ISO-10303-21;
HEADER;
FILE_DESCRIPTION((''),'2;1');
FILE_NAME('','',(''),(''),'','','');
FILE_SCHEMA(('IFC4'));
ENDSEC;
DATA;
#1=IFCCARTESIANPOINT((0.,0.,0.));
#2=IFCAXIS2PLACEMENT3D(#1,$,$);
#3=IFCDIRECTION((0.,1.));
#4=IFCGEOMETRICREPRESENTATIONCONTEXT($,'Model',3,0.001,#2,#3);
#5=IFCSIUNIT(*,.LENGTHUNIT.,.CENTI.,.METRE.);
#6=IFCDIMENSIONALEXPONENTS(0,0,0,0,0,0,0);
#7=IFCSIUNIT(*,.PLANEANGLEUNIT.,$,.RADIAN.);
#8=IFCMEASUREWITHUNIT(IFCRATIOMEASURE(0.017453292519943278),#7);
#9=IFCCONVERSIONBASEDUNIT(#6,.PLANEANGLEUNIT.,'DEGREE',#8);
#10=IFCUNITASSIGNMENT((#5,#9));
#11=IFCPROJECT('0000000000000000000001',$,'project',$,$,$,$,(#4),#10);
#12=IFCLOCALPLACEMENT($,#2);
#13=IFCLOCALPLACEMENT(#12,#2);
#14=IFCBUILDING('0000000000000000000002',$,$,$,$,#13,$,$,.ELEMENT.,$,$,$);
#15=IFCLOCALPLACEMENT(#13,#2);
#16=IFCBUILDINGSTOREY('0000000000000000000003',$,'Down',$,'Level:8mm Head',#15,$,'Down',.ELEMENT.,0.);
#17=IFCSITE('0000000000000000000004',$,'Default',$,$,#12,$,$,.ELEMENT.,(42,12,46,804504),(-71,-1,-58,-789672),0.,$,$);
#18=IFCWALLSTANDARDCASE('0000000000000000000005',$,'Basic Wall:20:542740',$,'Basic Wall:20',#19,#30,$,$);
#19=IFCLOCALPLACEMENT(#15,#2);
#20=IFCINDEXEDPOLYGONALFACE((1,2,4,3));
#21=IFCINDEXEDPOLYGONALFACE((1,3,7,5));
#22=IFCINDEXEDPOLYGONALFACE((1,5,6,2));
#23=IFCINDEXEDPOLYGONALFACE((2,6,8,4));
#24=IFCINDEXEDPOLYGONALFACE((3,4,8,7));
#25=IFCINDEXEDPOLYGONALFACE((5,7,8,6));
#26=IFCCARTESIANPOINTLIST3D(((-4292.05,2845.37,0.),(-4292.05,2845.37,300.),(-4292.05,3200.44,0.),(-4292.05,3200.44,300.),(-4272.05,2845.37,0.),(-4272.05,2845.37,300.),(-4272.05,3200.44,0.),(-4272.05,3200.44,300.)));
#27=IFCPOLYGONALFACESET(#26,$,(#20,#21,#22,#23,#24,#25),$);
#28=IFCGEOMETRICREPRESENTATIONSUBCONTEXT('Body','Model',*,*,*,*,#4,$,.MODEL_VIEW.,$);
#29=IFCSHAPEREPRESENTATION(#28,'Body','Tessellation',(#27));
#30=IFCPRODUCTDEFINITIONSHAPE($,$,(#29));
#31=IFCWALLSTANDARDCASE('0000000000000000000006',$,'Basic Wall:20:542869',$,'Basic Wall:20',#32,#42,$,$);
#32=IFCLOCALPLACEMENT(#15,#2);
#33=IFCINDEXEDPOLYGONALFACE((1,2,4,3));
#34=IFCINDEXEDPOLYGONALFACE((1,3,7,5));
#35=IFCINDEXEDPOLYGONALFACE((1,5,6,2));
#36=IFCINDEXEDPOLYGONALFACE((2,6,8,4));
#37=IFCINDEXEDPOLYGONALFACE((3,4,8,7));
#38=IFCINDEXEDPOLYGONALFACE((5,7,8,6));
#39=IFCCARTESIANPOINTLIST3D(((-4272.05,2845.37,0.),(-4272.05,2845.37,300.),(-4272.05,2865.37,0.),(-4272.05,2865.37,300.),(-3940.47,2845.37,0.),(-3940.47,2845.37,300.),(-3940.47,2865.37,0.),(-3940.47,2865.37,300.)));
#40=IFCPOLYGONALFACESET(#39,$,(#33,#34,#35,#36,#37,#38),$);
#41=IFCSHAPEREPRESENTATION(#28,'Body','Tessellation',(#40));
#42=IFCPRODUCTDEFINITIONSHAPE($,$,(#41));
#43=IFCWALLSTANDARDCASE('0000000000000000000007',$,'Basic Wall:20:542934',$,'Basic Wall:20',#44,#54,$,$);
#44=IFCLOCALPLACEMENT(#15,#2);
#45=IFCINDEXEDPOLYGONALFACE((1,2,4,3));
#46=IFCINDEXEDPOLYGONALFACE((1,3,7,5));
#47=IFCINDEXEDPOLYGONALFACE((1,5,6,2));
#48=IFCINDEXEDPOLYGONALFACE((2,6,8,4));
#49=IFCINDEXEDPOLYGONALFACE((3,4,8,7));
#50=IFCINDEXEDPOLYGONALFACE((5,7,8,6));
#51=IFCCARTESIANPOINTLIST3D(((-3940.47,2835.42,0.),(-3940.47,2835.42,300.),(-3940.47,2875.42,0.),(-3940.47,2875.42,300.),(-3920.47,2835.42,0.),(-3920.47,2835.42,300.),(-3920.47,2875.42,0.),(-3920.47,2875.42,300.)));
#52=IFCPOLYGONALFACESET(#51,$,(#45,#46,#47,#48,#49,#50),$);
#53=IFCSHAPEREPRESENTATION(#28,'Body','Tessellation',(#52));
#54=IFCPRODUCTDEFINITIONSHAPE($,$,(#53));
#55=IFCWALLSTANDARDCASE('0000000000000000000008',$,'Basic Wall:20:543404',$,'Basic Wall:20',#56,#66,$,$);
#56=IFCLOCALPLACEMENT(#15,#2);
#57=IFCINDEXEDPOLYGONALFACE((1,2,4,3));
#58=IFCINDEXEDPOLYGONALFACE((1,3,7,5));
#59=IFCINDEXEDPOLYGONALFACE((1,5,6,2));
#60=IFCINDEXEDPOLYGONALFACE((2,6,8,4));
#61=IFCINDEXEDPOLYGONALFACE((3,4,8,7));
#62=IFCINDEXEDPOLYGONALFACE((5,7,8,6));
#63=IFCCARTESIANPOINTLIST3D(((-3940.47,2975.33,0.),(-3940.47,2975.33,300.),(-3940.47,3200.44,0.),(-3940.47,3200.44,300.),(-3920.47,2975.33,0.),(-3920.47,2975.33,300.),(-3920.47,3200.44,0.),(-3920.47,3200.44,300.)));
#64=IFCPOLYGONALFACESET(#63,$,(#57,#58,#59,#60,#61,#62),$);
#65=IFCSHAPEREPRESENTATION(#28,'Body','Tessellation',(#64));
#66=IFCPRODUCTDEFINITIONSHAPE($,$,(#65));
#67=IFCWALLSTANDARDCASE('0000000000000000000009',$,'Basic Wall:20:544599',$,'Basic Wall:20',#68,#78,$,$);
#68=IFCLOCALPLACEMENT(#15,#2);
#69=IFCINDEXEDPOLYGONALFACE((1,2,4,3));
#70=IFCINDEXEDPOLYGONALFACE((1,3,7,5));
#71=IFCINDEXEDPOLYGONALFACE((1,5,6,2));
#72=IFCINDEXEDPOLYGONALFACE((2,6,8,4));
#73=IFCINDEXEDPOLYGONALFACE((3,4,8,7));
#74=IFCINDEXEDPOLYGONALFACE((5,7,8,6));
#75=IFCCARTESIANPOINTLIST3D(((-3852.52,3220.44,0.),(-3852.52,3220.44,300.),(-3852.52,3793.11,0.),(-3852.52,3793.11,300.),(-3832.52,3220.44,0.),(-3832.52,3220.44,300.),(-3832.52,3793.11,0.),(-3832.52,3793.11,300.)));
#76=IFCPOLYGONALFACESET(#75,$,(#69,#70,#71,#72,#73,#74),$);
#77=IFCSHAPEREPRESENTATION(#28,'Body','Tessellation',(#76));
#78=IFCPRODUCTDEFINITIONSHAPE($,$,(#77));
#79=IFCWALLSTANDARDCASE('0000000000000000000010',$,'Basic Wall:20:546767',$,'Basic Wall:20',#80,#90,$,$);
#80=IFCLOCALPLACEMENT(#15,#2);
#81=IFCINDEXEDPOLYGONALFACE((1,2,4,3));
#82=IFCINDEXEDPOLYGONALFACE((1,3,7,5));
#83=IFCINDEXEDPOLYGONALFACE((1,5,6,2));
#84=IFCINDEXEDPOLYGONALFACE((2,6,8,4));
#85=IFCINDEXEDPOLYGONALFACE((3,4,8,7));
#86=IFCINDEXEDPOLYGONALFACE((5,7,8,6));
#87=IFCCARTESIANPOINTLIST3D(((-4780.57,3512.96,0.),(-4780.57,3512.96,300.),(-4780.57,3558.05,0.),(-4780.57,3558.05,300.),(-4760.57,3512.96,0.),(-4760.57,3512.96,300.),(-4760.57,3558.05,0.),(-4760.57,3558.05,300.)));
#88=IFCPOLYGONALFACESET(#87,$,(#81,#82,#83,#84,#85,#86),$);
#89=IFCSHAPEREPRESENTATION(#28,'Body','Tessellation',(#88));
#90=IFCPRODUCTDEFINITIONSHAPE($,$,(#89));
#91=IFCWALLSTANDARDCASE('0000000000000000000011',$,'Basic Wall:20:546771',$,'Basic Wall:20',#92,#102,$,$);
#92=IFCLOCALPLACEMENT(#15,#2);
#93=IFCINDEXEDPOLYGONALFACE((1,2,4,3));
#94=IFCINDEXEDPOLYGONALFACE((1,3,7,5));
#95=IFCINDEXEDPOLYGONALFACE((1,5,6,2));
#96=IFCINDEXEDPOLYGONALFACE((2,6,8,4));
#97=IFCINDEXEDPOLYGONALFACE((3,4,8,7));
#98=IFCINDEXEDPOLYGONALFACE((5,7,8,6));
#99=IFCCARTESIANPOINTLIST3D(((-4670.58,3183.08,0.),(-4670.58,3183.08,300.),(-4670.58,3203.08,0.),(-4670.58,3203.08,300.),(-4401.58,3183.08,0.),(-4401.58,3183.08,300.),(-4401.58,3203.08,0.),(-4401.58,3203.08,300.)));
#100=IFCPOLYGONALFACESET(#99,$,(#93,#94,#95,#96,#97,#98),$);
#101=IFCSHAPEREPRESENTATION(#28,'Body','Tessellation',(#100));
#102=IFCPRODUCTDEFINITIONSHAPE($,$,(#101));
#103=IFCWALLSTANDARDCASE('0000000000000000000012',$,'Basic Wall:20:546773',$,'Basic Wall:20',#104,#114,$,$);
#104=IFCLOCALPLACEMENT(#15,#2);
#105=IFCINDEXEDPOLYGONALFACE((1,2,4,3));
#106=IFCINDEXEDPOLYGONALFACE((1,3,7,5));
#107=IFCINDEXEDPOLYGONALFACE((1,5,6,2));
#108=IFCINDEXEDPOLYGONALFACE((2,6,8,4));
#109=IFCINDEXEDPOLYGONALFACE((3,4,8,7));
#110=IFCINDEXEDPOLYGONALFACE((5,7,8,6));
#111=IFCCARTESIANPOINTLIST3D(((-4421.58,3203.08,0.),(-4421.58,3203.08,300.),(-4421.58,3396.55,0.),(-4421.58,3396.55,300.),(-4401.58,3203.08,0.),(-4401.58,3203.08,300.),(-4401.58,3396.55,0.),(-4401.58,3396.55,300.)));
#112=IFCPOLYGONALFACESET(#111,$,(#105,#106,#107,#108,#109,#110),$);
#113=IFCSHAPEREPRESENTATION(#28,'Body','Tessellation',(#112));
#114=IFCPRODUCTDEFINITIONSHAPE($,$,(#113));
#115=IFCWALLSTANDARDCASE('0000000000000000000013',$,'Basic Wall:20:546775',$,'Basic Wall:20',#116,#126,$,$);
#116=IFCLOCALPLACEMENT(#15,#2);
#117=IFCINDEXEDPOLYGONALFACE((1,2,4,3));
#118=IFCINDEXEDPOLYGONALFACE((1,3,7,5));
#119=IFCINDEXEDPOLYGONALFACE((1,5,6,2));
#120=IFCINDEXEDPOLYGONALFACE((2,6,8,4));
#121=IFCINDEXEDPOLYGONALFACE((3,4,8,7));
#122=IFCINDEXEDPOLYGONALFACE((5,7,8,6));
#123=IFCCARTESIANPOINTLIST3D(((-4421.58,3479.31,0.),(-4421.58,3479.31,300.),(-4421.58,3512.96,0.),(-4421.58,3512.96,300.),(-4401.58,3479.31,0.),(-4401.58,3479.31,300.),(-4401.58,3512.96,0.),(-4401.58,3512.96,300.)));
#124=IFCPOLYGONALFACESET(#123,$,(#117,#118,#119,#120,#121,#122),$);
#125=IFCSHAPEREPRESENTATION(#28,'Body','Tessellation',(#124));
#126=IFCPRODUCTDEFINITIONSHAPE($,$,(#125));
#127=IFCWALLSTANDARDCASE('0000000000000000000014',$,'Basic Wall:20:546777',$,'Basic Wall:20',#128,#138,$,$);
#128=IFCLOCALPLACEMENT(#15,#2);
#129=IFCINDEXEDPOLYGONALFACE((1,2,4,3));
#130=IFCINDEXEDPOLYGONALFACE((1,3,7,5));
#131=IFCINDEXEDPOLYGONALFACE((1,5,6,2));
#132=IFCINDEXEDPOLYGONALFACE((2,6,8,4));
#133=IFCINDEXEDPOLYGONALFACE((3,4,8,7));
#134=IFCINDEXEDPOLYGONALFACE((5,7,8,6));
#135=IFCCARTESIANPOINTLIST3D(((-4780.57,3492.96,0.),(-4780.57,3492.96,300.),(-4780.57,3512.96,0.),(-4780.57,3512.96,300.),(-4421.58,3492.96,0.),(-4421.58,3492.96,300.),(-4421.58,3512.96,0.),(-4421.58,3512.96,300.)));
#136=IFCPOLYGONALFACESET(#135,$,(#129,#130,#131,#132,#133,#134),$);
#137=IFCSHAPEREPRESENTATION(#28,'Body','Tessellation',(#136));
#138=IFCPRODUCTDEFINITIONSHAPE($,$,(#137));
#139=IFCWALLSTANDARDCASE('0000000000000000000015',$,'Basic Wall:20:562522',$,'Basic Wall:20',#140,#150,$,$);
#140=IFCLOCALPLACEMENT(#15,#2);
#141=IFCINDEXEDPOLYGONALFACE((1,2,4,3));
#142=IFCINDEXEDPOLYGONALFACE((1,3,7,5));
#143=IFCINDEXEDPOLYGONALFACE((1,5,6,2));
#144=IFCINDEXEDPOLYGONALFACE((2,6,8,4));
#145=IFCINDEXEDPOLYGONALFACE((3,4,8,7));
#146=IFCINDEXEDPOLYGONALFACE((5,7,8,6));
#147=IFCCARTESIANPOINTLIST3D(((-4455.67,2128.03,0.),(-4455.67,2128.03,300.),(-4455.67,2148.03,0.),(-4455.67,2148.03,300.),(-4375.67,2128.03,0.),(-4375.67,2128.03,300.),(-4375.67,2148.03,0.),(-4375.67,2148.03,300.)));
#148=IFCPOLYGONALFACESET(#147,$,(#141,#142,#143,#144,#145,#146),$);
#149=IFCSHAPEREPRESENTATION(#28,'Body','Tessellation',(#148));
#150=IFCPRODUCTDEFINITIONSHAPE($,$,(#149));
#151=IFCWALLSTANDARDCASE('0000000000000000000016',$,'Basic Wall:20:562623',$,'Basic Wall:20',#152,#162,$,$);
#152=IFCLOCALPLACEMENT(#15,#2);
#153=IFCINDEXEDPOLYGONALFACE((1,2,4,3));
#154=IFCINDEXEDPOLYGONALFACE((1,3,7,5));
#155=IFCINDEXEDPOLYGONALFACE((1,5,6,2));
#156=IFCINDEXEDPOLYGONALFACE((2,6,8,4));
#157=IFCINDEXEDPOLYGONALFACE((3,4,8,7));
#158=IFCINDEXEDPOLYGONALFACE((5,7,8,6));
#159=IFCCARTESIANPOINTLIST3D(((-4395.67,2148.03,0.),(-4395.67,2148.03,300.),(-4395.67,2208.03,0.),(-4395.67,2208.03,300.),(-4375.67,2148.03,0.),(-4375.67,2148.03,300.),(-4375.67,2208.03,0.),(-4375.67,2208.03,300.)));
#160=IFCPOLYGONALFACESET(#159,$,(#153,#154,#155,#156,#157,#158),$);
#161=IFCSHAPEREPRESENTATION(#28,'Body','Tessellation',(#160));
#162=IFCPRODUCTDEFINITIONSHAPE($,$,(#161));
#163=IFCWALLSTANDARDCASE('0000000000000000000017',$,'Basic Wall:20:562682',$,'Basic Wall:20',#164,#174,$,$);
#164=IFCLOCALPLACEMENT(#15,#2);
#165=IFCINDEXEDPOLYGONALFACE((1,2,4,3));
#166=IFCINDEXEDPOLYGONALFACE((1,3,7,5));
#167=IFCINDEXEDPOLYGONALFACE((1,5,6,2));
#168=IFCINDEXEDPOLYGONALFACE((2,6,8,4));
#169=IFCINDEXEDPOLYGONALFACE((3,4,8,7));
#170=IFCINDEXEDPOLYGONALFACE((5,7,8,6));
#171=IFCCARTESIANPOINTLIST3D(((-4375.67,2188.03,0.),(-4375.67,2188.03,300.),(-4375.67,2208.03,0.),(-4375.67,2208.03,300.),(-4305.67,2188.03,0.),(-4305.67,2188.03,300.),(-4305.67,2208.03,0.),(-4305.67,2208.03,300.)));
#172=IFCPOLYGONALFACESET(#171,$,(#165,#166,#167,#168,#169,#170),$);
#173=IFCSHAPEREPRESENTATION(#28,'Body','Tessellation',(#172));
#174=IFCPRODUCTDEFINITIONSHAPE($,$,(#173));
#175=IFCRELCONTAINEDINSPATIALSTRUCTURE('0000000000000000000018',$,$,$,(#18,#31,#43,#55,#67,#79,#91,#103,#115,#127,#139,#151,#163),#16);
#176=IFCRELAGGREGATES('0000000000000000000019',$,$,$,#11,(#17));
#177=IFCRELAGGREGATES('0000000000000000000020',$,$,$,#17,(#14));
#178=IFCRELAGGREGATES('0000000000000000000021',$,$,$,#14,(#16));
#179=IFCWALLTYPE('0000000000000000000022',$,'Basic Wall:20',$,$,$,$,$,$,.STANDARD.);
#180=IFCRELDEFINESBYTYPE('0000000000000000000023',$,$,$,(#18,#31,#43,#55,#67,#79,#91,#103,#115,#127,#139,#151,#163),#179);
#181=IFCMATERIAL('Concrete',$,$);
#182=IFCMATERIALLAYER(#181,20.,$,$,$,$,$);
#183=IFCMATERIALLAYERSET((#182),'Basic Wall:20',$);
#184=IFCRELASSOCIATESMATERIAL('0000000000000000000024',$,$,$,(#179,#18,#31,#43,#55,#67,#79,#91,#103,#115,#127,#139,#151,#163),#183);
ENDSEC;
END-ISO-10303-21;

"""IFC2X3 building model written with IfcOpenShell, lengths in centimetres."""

from ifc_helpers import new_model, entity, si_unit, converted_unit, direction, frame, frame_2d, origin, place, context, subcontext, project, spatial, rectangle, extrude, material, layer, layer_set, layer_usage, type_object, element, save


model = new_model("IFC2X3")

# Units and contexts
model_context = context("Model", 3, precision=0.001, world=origin(), true_north=direction((0.0, 1.0)))
body_context = subcontext(model_context, "Body", "Model", "MODEL_VIEW")
ifc_project = project(units=[si_unit("LENGTHUNIT", "METRE", prefix="CENTI"), converted_unit("PLANEANGLEUNIT", "DEGREE", entity("IfcRatioMeasure", 0.017453292519943278), si_unit("PLANEANGLEUNIT", "RADIAN"), dimensions=[0, 0, 0, 0, 0, 0, 0])], contexts=[model_context])

# Site, building, storey
site_placement = place(None, origin())
site = spatial("IfcSite", under=ifc_project, at=site_placement, Name="Default", CompositionType="ELEMENT", RefLatitude=(42, 12, 46, 804504), RefLongitude=(-71, -1, -58, -789672), RefElevation=0.0)
building_placement = place(site_placement, origin())
building = spatial("IfcBuilding", under=site, at=building_placement, CompositionType="ELEMENT")
storey_placement = place(building_placement, origin())
storey = spatial("IfcBuildingStorey", under=building, at=storey_placement, Name="Down", ObjectType="Level:8mm Head", LongName="Down", CompositionType="ELEMENT", Elevation=0.0)

# Walls
ifc_material = material(Name="Concrete")
ifc_layer_1 = layer(ifc_material, 20.0)
ifc_layer_set_1 = layer_set([ifc_layer_1], Name="Basic Wall:20")
wall_type_1 = type_object("IfcWallType", Name="Basic Wall:20", PredefinedType="STANDARD", material=ifc_layer_set_1)
ifc_layer_usage_1 = layer_usage(ifc_layer_set_1, "AXIS2", "POSITIVE", -10.0)
wall_1_placement = place(storey_placement, frame((-4282.05, 3200.44, 0.0), z_axis=(0.0, 0.0, 1.0), x_axis=(0.0, -1.0, 0.0)))
element("IfcWallStandardCase", 1, at=wall_1_placement, inside=storey, type_object=wall_type_1, material=ifc_layer_usage_1, Name="Basic Wall:20:542740", ObjectType="Basic Wall:20", context=body_context, shape_type="SweptSolid", body=[
    extrude(rectangle(XDim=355.07, YDim=20.0, at=frame_2d((177.54, 0.0), x_axis=(-1.0, 0.0))), origin(), (0.0, 0.0, 1.0), 300.0),
])
ifc_layer_usage_2 = layer_usage(ifc_layer_set_1, "AXIS2", "POSITIVE", -10.0)
wall_2_placement = place(storey_placement, frame((-4272.05, 2855.37, 0.0)))
element("IfcWallStandardCase", 2, at=wall_2_placement, inside=storey, type_object=wall_type_1, material=ifc_layer_usage_2, Name="Basic Wall:20:542869", ObjectType="Basic Wall:20", context=body_context, shape_type="SweptSolid", body=[
    extrude(rectangle(XDim=331.58, YDim=20.0, at=frame_2d((165.79, 0.0), x_axis=(-1.0, 0.0))), origin(), (0.0, 0.0, 1.0), 300.0),
])
ifc_layer_usage_3 = layer_usage(ifc_layer_set_1, "AXIS2", "NEGATIVE", 10.0)
wall_3_placement = place(storey_placement, frame((-3930.47, 2875.42, 0.0), z_axis=(0.0, 0.0, 1.0), x_axis=(0.0, -1.0, 0.0)))
element("IfcWallStandardCase", 3, at=wall_3_placement, inside=storey, type_object=wall_type_1, material=ifc_layer_usage_3, Name="Basic Wall:20:542934", ObjectType="Basic Wall:20", context=body_context, shape_type="SweptSolid", body=[
    extrude(rectangle(XDim=40.0, YDim=20.0, at=frame_2d((20.0, 0.0), x_axis=(-1.0, 0.0))), origin(), (0.0, 0.0, 1.0), 300.0),
])
ifc_layer_usage_4 = layer_usage(ifc_layer_set_1, "AXIS2", "NEGATIVE", 10.0)
wall_4_placement = place(storey_placement, frame((-3930.47, 2975.33, 0.0), z_axis=(0.0, 0.0, 1.0), x_axis=(0.0, 1.0, 0.0)))
element("IfcWallStandardCase", 4, at=wall_4_placement, inside=storey, type_object=wall_type_1, material=ifc_layer_usage_4, Name="Basic Wall:20:543404", ObjectType="Basic Wall:20", context=body_context, shape_type="SweptSolid", body=[
    extrude(rectangle(XDim=225.11, YDim=20.0, at=frame_2d((112.56, 0.0), x_axis=(-1.0, 0.0))), origin(), (0.0, 0.0, 1.0), 300.0),
])
ifc_layer_usage_5 = layer_usage(ifc_layer_set_1, "AXIS2", "POSITIVE", -10.0)
wall_5_placement = place(storey_placement, frame((-3842.52, 3220.44, 0.0), z_axis=(0.0, 0.0, 1.0), x_axis=(0.0, 1.0, 0.0)))
element("IfcWallStandardCase", 5, at=wall_5_placement, inside=storey, type_object=wall_type_1, material=ifc_layer_usage_5, Name="Basic Wall:20:544599", ObjectType="Basic Wall:20", context=body_context, shape_type="SweptSolid", body=[
    extrude(rectangle(XDim=572.67, YDim=20.0, at=frame_2d((286.33, 0.0), x_axis=(-1.0, 0.0))), origin(), (0.0, 0.0, 1.0), 300.0),
])
ifc_layer_usage_6 = layer_usage(ifc_layer_set_1, "AXIS2", "NEGATIVE", 10.0)
wall_6_placement = place(storey_placement, frame((-4770.57, 3558.05, 0.0), z_axis=(0.0, 0.0, 1.0), x_axis=(0.0, -1.0, 0.0)))
element("IfcWallStandardCase", 6, at=wall_6_placement, inside=storey, type_object=wall_type_1, material=ifc_layer_usage_6, Name="Basic Wall:20:546767", ObjectType="Basic Wall:20", context=body_context, shape_type="SweptSolid", body=[
    extrude(rectangle(XDim=45.08, YDim=20.0, at=frame_2d((22.54, 0.0), x_axis=(-1.0, 0.0))), origin(), (0.0, 0.0, 1.0), 300.0),
])
ifc_layer_usage_7 = layer_usage(ifc_layer_set_1, "AXIS2", "NEGATIVE", 10.0)
wall_7_placement = place(storey_placement, frame((-4670.58, 3193.08, 0.0)))
element("IfcWallStandardCase", 7, at=wall_7_placement, inside=storey, type_object=wall_type_1, material=ifc_layer_usage_7, Name="Basic Wall:20:546771", ObjectType="Basic Wall:20", context=body_context, shape_type="SweptSolid", body=[
    extrude(rectangle(XDim=268.99, YDim=20.0, at=frame_2d((134.5, 0.0), x_axis=(-1.0, 0.0))), origin(), (0.0, 0.0, 1.0), 300.0),
])
ifc_layer_usage_8 = layer_usage(ifc_layer_set_1, "AXIS2", "POSITIVE", -10.0)
wall_8_placement = place(storey_placement, frame((-4411.58, 3203.08, 0.0), z_axis=(0.0, 0.0, 1.0), x_axis=(0.0, 1.0, 0.0)))
element("IfcWallStandardCase", 8, at=wall_8_placement, inside=storey, type_object=wall_type_1, material=ifc_layer_usage_8, Name="Basic Wall:20:546773", ObjectType="Basic Wall:20", context=body_context, shape_type="SweptSolid", body=[
    extrude(rectangle(XDim=193.46, YDim=20.0, at=frame_2d((96.73, 0.0), x_axis=(-1.0, 0.0))), origin(), (0.0, 0.0, 1.0), 300.0),
])
ifc_layer_usage_9 = layer_usage(ifc_layer_set_1, "AXIS2", "POSITIVE", -10.0)
wall_9_placement = place(storey_placement, frame((-4411.58, 3479.31, 0.0), z_axis=(0.0, 0.0, 1.0), x_axis=(0.0, 1.0, 0.0)))
element("IfcWallStandardCase", 9, at=wall_9_placement, inside=storey, type_object=wall_type_1, material=ifc_layer_usage_9, Name="Basic Wall:20:546775", ObjectType="Basic Wall:20", context=body_context, shape_type="SweptSolid", body=[
    extrude(rectangle(XDim=33.66, YDim=20.0, at=frame_2d((16.83, 0.0), x_axis=(-1.0, 0.0))), origin(), (0.0, 0.0, 1.0), 300.0),
])
ifc_layer_usage_10 = layer_usage(ifc_layer_set_1, "AXIS2", "POSITIVE", -10.0)
wall_10_placement = place(storey_placement, frame((-4421.58, 3502.96, 0.0), z_axis=(0.0, 0.0, 1.0), x_axis=(-1.0, 0.0, 0.0)))
element("IfcWallStandardCase", 10, at=wall_10_placement, inside=storey, type_object=wall_type_1, material=ifc_layer_usage_10, Name="Basic Wall:20:546777", ObjectType="Basic Wall:20", context=body_context, shape_type="SweptSolid", body=[
    extrude(rectangle(XDim=358.99, YDim=20.0, at=frame_2d((179.49, 0.0), x_axis=(-1.0, 0.0))), origin(), (0.0, 0.0, 1.0), 300.0),
])
ifc_layer_usage_11 = layer_usage(ifc_layer_set_1, "AXIS2", "NEGATIVE", 10.0)
wall_11_placement = place(storey_placement, frame((-4455.67, 2138.03, 0.0)))
element("IfcWallStandardCase", 11, at=wall_11_placement, inside=storey, type_object=wall_type_1, material=ifc_layer_usage_11, Name="Basic Wall:20:562522", ObjectType="Basic Wall:20", context=body_context, shape_type="SweptSolid", body=[
    extrude(rectangle(XDim=80.0, YDim=20.0, at=frame_2d((40.0, 0.0), x_axis=(-1.0, 0.0))), origin(), (0.0, 0.0, 1.0), 300.0),
])
ifc_layer_usage_12 = layer_usage(ifc_layer_set_1, "AXIS2", "NEGATIVE", 10.0)
wall_12_placement = place(storey_placement, frame((-4385.67, 2148.03, 0.0), z_axis=(0.0, 0.0, 1.0), x_axis=(0.0, 1.0, 0.0)))
element("IfcWallStandardCase", 12, at=wall_12_placement, inside=storey, type_object=wall_type_1, material=ifc_layer_usage_12, Name="Basic Wall:20:562623", ObjectType="Basic Wall:20", context=body_context, shape_type="SweptSolid", body=[
    extrude(rectangle(XDim=60.0, YDim=20.0, at=frame_2d((30.0, 0.0), x_axis=(-1.0, 0.0))), origin(), (0.0, 0.0, 1.0), 300.0),
])
ifc_layer_usage_13 = layer_usage(ifc_layer_set_1, "AXIS2", "NEGATIVE", 10.0)
wall_13_placement = place(storey_placement, frame((-4375.67, 2198.03, 0.0)))
element("IfcWallStandardCase", 13, at=wall_13_placement, inside=storey, type_object=wall_type_1, material=ifc_layer_usage_13, Name="Basic Wall:20:562682", ObjectType="Basic Wall:20", context=body_context, shape_type="SweptSolid", body=[
    extrude(rectangle(XDim=70.0, YDim=20.0, at=frame_2d((35.0, 0.0), x_axis=(-1.0, 0.0))), origin(), (0.0, 0.0, 1.0), 300.0),
])

save(model, "model.ifc")
